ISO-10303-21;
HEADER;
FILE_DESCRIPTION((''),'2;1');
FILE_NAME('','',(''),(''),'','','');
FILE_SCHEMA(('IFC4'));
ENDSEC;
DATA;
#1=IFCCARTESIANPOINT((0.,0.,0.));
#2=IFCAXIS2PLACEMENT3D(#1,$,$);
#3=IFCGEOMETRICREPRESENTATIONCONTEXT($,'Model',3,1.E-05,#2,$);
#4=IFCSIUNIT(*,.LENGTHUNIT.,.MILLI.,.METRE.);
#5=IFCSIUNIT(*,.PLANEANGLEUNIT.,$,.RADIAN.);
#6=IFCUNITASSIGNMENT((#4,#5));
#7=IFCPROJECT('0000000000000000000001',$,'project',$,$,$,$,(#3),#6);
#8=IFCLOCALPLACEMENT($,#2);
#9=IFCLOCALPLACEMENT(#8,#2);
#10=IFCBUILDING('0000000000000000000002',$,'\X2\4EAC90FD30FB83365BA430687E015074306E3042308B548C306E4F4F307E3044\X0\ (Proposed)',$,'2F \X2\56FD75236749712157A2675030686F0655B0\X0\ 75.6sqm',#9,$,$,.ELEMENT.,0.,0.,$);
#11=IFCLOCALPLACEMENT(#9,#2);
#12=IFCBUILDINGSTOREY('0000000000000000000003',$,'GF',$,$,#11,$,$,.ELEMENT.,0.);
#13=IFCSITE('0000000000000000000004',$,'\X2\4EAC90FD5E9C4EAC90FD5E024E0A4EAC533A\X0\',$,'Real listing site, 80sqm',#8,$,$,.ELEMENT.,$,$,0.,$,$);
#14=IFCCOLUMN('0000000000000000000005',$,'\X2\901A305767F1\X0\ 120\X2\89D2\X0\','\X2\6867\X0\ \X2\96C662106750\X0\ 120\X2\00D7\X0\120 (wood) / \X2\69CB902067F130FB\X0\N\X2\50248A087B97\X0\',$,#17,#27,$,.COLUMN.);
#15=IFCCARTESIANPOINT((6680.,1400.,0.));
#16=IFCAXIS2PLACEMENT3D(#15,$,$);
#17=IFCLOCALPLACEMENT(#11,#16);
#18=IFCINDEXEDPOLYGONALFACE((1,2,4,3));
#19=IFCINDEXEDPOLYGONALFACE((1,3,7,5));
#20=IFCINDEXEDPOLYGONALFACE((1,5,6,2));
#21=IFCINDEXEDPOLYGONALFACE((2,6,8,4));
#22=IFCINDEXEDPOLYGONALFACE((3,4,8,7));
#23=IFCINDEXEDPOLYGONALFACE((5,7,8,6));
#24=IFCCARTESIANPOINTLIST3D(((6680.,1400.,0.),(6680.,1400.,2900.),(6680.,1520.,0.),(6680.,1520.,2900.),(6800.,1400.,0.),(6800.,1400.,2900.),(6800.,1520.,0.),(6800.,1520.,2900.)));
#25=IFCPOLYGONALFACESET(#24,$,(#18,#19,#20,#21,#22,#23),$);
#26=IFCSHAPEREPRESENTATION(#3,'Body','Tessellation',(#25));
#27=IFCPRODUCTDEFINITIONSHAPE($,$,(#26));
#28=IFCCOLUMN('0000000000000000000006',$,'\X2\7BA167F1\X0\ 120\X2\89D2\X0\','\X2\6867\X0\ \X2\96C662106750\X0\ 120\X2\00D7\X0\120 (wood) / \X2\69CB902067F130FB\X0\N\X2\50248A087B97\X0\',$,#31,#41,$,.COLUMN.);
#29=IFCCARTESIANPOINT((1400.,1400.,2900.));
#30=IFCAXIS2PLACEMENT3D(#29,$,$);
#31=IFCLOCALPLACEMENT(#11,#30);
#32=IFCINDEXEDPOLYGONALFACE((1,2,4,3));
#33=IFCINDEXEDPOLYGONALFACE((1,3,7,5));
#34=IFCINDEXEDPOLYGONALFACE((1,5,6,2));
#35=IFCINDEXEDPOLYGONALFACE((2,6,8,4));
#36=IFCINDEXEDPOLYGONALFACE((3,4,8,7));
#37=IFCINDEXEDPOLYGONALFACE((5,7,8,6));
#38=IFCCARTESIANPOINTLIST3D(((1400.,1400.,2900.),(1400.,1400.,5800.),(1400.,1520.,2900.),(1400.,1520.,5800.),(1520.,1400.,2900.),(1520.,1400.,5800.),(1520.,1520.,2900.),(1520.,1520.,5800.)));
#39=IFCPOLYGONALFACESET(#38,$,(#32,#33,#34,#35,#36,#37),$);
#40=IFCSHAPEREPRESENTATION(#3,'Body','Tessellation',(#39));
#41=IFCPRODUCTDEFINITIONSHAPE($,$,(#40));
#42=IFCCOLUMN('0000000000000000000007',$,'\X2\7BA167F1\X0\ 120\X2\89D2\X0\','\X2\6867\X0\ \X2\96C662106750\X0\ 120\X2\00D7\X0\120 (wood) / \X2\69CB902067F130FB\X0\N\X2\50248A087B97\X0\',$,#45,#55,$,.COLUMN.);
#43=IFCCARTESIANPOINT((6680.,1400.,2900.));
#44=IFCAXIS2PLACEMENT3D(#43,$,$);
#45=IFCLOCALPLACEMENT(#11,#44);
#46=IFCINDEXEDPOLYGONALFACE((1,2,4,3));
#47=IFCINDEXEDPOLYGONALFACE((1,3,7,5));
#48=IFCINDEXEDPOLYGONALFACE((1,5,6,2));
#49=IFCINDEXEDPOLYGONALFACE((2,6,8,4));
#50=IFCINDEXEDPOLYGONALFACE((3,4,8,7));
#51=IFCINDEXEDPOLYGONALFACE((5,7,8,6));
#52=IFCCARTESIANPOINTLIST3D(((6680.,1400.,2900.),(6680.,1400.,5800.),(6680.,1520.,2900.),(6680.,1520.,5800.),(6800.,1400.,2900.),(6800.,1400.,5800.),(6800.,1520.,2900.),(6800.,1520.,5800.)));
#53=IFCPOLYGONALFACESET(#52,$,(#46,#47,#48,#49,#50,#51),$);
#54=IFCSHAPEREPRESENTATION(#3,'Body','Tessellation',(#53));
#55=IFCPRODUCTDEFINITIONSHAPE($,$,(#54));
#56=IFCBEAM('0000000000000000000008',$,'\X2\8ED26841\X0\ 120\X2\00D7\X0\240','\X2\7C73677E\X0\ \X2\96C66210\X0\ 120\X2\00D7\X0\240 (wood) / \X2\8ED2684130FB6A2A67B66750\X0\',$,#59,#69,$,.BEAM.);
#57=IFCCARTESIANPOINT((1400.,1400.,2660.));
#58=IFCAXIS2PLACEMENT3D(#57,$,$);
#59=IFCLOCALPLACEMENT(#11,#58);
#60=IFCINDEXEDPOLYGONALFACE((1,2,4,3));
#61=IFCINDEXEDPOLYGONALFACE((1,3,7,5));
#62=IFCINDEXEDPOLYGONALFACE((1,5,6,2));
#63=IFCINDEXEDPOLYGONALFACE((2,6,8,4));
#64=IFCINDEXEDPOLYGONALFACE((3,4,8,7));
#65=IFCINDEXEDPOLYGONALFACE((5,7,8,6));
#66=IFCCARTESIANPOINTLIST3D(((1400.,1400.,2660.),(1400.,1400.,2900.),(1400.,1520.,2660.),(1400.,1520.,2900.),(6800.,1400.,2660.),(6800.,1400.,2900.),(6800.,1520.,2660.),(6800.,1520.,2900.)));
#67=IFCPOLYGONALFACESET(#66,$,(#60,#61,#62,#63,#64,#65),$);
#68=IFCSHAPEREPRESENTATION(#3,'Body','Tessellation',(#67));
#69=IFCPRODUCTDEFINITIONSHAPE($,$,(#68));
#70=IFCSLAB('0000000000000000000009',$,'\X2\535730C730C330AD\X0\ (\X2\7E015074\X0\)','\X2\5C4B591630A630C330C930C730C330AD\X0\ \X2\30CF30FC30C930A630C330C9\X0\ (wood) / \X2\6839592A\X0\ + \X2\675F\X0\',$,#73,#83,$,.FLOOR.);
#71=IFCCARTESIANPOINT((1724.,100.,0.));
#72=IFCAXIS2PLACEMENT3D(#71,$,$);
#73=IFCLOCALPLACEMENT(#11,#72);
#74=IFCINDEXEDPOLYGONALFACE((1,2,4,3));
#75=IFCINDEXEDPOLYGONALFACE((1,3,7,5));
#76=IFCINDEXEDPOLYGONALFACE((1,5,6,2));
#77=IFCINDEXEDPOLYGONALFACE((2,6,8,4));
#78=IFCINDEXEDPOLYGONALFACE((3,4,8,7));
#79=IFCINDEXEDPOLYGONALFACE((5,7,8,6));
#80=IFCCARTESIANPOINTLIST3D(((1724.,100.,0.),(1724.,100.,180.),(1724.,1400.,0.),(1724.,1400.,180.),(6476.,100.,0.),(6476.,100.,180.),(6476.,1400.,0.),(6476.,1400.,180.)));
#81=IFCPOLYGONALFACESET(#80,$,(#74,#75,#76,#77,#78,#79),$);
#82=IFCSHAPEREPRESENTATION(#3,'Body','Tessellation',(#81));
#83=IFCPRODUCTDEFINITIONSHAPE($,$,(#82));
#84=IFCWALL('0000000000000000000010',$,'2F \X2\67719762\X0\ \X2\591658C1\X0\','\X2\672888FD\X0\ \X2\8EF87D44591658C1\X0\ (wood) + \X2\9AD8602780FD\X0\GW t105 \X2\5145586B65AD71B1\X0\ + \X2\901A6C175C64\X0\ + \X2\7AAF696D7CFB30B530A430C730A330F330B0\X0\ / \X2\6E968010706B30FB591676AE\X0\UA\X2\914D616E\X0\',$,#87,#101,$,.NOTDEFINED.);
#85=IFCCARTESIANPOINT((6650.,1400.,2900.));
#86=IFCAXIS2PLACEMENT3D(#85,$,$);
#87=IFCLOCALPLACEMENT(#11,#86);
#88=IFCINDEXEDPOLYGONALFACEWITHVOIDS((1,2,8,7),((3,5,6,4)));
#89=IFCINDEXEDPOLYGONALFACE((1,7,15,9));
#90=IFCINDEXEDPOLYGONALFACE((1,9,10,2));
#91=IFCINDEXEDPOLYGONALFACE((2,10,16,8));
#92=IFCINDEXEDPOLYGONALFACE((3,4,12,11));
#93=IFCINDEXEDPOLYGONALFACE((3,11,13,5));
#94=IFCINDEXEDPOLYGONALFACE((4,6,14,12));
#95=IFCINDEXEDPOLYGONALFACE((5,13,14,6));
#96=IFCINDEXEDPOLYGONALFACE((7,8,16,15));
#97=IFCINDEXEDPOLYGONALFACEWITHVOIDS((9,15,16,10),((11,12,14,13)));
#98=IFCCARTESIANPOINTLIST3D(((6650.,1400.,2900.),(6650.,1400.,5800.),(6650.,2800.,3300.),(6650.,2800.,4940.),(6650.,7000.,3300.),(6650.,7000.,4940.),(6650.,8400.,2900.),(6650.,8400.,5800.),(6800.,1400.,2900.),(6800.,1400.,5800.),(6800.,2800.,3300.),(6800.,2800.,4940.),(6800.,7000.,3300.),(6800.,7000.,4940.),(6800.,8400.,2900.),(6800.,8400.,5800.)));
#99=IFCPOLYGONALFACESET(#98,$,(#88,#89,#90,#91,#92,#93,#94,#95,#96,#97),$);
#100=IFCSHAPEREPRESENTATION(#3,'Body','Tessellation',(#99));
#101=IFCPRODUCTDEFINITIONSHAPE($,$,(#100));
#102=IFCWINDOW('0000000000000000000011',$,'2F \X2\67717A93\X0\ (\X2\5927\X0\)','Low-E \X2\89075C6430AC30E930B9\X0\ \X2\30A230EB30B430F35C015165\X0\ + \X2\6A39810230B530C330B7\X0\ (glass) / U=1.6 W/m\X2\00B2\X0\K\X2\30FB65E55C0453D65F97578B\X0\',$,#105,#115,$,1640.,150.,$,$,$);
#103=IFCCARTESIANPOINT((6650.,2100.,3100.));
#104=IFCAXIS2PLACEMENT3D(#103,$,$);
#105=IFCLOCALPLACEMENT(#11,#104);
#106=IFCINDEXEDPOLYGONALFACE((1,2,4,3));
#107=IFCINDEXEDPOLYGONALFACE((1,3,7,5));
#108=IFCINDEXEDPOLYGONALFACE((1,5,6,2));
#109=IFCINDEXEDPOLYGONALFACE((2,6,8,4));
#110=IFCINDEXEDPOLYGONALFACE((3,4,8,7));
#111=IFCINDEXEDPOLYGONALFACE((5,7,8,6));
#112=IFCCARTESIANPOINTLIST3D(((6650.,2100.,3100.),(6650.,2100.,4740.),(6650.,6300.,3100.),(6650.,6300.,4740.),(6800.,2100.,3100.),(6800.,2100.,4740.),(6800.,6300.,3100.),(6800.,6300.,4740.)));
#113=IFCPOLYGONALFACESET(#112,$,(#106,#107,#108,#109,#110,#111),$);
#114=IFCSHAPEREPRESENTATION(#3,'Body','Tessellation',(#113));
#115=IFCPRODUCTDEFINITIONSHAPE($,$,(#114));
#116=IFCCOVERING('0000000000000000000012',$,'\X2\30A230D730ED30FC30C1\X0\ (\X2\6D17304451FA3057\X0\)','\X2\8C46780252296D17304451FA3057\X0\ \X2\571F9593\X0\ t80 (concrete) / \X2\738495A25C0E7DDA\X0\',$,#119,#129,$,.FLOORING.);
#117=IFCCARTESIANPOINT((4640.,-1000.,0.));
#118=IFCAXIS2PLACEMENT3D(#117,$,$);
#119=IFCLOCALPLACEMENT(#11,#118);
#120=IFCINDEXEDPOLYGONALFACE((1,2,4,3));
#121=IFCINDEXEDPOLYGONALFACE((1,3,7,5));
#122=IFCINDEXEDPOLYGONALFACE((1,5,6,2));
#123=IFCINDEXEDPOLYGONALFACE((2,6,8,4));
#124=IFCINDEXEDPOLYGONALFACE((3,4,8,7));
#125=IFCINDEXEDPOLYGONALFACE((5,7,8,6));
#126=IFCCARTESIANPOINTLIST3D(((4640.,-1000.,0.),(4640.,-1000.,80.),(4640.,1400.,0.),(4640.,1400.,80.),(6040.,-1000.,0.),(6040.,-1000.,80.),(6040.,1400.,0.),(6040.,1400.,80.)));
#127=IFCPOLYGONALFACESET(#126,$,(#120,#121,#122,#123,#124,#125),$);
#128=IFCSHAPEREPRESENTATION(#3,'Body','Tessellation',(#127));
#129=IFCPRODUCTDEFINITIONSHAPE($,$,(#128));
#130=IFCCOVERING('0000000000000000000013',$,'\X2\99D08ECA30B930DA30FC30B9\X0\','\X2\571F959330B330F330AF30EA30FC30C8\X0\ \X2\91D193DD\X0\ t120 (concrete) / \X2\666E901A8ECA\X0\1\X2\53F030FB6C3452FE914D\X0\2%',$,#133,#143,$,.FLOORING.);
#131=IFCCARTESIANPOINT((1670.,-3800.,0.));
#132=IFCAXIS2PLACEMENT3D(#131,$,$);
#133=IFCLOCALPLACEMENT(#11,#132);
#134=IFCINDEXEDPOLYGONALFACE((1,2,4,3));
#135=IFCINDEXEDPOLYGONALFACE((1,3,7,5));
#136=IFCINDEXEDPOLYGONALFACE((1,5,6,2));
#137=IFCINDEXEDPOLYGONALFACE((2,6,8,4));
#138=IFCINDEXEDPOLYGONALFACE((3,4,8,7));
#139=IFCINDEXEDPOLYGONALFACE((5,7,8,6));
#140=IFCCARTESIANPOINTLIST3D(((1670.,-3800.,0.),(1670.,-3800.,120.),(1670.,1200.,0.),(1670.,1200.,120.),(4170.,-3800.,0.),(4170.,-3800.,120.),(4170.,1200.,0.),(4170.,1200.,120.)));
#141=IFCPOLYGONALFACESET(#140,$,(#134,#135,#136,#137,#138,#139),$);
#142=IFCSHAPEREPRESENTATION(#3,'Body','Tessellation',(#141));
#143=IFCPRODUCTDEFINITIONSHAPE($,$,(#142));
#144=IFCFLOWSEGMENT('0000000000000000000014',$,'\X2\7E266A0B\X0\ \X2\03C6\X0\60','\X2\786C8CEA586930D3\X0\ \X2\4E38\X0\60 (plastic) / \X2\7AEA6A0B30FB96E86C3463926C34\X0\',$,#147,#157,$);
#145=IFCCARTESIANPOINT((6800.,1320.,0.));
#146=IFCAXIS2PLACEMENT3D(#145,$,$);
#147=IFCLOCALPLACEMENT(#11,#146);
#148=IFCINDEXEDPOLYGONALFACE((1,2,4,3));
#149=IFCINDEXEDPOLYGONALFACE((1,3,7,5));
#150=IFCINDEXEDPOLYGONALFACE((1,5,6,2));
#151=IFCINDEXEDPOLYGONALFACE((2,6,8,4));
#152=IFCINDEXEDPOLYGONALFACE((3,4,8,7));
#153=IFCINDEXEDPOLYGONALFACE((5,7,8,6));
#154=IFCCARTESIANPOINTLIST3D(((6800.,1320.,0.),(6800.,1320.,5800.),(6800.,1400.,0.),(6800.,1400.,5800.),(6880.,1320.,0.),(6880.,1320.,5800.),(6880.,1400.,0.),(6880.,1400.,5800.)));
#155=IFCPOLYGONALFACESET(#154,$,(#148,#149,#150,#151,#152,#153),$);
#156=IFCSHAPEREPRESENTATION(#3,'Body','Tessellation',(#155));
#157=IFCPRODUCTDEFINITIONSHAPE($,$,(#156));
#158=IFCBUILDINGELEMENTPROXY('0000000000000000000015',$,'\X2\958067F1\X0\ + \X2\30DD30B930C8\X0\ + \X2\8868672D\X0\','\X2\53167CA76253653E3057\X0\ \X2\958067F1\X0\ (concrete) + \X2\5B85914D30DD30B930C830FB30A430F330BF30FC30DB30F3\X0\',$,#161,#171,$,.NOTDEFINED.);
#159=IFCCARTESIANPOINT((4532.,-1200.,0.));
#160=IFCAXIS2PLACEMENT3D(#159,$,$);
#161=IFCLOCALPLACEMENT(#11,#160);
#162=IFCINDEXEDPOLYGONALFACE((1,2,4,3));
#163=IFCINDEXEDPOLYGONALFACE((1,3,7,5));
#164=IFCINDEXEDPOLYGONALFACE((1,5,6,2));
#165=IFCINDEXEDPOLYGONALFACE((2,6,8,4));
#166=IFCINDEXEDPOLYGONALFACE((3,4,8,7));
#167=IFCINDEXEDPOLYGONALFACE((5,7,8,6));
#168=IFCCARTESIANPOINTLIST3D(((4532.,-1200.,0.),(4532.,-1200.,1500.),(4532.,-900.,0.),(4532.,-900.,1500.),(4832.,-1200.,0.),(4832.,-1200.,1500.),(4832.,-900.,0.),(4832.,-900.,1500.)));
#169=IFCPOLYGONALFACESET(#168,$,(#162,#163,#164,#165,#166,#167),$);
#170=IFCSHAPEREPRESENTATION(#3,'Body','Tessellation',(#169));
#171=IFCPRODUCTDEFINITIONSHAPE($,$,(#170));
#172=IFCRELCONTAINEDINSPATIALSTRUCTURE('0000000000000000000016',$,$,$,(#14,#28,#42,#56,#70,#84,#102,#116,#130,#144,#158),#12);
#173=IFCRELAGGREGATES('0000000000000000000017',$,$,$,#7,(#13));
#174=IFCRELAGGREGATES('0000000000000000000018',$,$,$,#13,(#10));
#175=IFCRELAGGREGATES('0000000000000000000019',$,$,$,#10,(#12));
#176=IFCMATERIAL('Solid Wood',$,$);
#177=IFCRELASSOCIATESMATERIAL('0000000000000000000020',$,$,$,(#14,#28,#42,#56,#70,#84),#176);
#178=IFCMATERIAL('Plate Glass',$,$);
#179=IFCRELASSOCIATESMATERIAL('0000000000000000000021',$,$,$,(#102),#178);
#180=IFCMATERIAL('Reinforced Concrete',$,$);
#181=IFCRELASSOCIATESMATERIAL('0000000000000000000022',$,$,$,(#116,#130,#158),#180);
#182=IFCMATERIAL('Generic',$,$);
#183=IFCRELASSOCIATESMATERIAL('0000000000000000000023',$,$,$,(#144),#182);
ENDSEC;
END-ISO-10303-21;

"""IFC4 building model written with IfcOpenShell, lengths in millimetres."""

from ifc_helpers import new_model, si_unit, frame, frame_2d, origin, place, context, project, spatial, rectangle, extrude, material, element, fill, save


model = new_model("IFC4")

# Units and contexts
model_context = context("Model", 3, precision=1e-05, world=origin())
ifc_project = project(units=[si_unit("LENGTHUNIT", "METRE", prefix="MILLI"), si_unit("PLANEANGLEUNIT", "RADIAN")], contexts=[model_context])

# Site, building, storey
site_placement = place(None, origin())
site = spatial("IfcSite", under=ifc_project, at=site_placement, Name="京都府京都市上京区", ObjectType="Real listing site, 80sqm", CompositionType="ELEMENT", RefElevation=0.0)
building_placement = place(site_placement, origin())
building = spatial("IfcBuilding", under=site, at=building_placement, Name="京都・茶室と縁側のある和の住まい (Proposed)", ObjectType="2F 国産杉無垢材と漆喰 75.6sqm", CompositionType="ELEMENT", ElevationOfRefHeight=0.0, ElevationOfTerrain=0.0)
storey_placement = place(building_placement, origin())
storey = spatial("IfcBuildingStorey", under=building, at=storey_placement, Name="GF", CompositionType="ELEMENT", Elevation=0.0)

# Columns
ifc_material_1 = material(Name="Solid Wood")
column_1_placement = place(storey_placement, frame((6680.0, 1400.0, 0.0)))
element("IfcColumn", 1, at=column_1_placement, inside=storey, material=ifc_material_1, Name="通し柱 120角", Description="桧 集成材 120×120 (wood) / 構造柱・N値計算", PredefinedType="COLUMN", context=model_context, shape_type="SweptSolid", body=[
    extrude(rectangle(XDim=120.0, YDim=120.0, at=frame_2d((60.0, 60.0))), frame((6680.0, 1400.0, 0.0)), (0.0, 0.0, 1.0), 2900.0),
])
column_2_placement = place(storey_placement, frame((1400.0, 1400.0, 2900.0)))
element("IfcColumn", 2, at=column_2_placement, inside=storey, material=ifc_material_1, Name="管柱 120角", Description="桧 集成材 120×120 (wood) / 構造柱・N値計算", PredefinedType="COLUMN", context=model_context, shape_type="SweptSolid", body=[
    extrude(rectangle(XDim=120.0, YDim=120.0, at=frame_2d((60.0, 60.0))), frame((1400.0, 1400.0, 2900.0)), (0.0, 0.0, 1.0), 2900.0),
])
column_3_placement = place(storey_placement, frame((6680.0, 1400.0, 2900.0)))
element("IfcColumn", 3, at=column_3_placement, inside=storey, material=ifc_material_1, Name="管柱 120角", Description="桧 集成材 120×120 (wood) / 構造柱・N値計算", PredefinedType="COLUMN", context=model_context, shape_type="SweptSolid", body=[
    extrude(rectangle(XDim=120.0, YDim=120.0, at=frame_2d((60.0, 60.0))), frame((6680.0, 1400.0, 2900.0)), (0.0, 0.0, 1.0), 2900.0),
])

# Beam
beam_1_placement = place(storey_placement, frame((1400.0, 1400.0, 2660.0)))
element("IfcBeam", 4, at=beam_1_placement, inside=storey, material=ifc_material_1, Name="軒桁 120×240", Description="米松 集成 120×240 (wood) / 軒桁・横架材", PredefinedType="BEAM", context=model_context, shape_type="SweptSolid", body=[
    extrude(rectangle(XDim=5400.0, YDim=120.0, at=frame_2d((2700.0, 60.0))), frame((1400.0, 1400.0, 2660.0)), (0.0, 0.0, 1.0), 240.0),
])

# Slab
slab_placement = place(storey_placement, frame((1724.0, 100.0, 0.0)))
element("IfcSlab", 5, at=slab_placement, inside=storey, material=ifc_material_1, Name="南デッキ (縁側)", Description="屋外ウッドデッキ ハードウッド (wood) / 根太 + 束", PredefinedType="FLOOR", context=model_context, shape_type="SweptSolid", body=[
    extrude(rectangle(XDim=4752.0, YDim=1300.0, at=frame_2d((2376.0, 650.0))), frame((1724.0, 100.0, 0.0)), (0.0, 0.0, 1.0), 180.0),
])

# Wall, opening, window
ifc_material_2 = material(Name="Plate Glass")
wall_1_placement = place(storey_placement, frame((6650.0, 1400.0, 2900.0)))
wall_1 = element("IfcWall", 6, at=wall_1_placement, inside=storey, material=ifc_material_1, Name="2F 東面 外壁", Description="木製 軸組外壁 (wood) + 高性能GW t105 充填断熱 + 通気層 + 窯業系サイディング / 準耐火・外皮UA配慮", PredefinedType="NOTDEFINED", context=model_context, shape_type="SweptSolid", body=[
    extrude(rectangle(XDim=150.0, YDim=7000.0, at=frame_2d((75.0, 3500.0))), frame((6650.0, 1400.0, 2900.0)), (0.0, 0.0, 1.0), 2900.0),
])
opening_1_placement = place(storey_placement, frame((6650.0, 2100.0, 3100.0)))
opening_1 = element("IfcOpeningElement", 7, at=opening_1_placement, cuts=wall_1, PredefinedType="NOTDEFINED", context=model_context, shape_type="SweptSolid", body=[
    extrude(rectangle(XDim=150.0, YDim=4200.0, at=frame_2d((75.0, 2100.0))), frame((6650.0, 2100.0, 3100.0)), (0.0, 0.0, 1.0), 1640.0),
])
window_1_placement = place(storey_placement, frame((6650.0, 2100.0, 3100.0)))
window_1 = element("IfcWindow", 8, at=window_1_placement, inside=storey, material=ifc_material_2, Name="2F 東窓 (大)", Description="Low-E 複層ガラス アルゴン封入 + 樹脂サッシ (glass) / U=1.6 W/m²K・日射取得型", OverallHeight=1640.0, OverallWidth=150.0, context=model_context, shape_type="SweptSolid", body=[
    extrude(rectangle(XDim=150.0, YDim=4200.0, at=frame_2d((75.0, 2100.0))), frame((6650.0, 2100.0, 3100.0)), (0.0, 0.0, 1.0), 1640.0),
])
fill(opening_1, window_1)

# Coverings
ifc_material_3 = material(Name="Reinforced Concrete")
covering_1_placement = place(storey_placement, frame((4640.0, -1000.0, 0.0)))
element("IfcCovering", 9, at=covering_1_placement, inside=storey, material=ifc_material_3, Name="アプローチ (洗い出し)", Description="豆砂利洗い出し 土間 t80 (concrete) / 玄関導線", PredefinedType="FLOORING", context=model_context, shape_type="SweptSolid", body=[
    extrude(rectangle(XDim=1400.0, YDim=2400.0, at=frame_2d((700.0, 1200.0))), frame((4640.0, -1000.0, 0.0)), (0.0, 0.0, 1.0), 80.0),
])
covering_2_placement = place(storey_placement, frame((1670.0, -3800.0, 0.0)))
element("IfcCovering", 10, at=covering_2_placement, inside=storey, material=ifc_material_3, Name="駐車スペース", Description="土間コンクリート 金鏝 t120 (concrete) / 普通車1台・水勾配2%", PredefinedType="FLOORING", context=model_context, shape_type="SweptSolid", body=[
    extrude(rectangle(XDim=2500.0, YDim=5000.0, at=frame_2d((1250.0, 2500.0))), frame((1670.0, -3800.0, 0.0)), (0.0, 0.0, 1.0), 120.0),
])

# Flow segment
ifc_material_4 = material(Name="Generic")
flow_segment_placement = place(storey_placement, frame((6800.0, 1320.0, 0.0)))
element("IfcFlowSegment", 11, at=flow_segment_placement, inside=storey, material=ifc_material_4, Name="縦樋 φ60", Description="硬質塩ビ 丸60 (plastic) / 竪樋・雨水排水", context=model_context, shape_type="SweptSolid", body=[
    extrude(rectangle(XDim=80.0, YDim=80.0, at=frame_2d((40.0, 40.0))), frame((6800.0, 1320.0, 0.0)), (0.0, 0.0, 1.0), 5800.0),
])

# Building element proxy
proxy_placement = place(storey_placement, frame((4532.0, -1200.0, 0.0)))
element("IfcBuildingElementProxy", 12, at=proxy_placement, inside=storey, material=ifc_material_3, Name="門柱 + ポスト + 表札", Description="化粧打放し 門柱 (concrete) + 宅配ポスト・インターホン", PredefinedType="NOTDEFINED", context=model_context, shape_type="SweptSolid", body=[
    extrude(rectangle(XDim=300.0, YDim=300.0, at=frame_2d((150.0, 150.0))), frame((4532.0, -1200.0, 0.0)), (0.0, 0.0, 1.0), 1500.0),
])

save(model, "model.ifc")
